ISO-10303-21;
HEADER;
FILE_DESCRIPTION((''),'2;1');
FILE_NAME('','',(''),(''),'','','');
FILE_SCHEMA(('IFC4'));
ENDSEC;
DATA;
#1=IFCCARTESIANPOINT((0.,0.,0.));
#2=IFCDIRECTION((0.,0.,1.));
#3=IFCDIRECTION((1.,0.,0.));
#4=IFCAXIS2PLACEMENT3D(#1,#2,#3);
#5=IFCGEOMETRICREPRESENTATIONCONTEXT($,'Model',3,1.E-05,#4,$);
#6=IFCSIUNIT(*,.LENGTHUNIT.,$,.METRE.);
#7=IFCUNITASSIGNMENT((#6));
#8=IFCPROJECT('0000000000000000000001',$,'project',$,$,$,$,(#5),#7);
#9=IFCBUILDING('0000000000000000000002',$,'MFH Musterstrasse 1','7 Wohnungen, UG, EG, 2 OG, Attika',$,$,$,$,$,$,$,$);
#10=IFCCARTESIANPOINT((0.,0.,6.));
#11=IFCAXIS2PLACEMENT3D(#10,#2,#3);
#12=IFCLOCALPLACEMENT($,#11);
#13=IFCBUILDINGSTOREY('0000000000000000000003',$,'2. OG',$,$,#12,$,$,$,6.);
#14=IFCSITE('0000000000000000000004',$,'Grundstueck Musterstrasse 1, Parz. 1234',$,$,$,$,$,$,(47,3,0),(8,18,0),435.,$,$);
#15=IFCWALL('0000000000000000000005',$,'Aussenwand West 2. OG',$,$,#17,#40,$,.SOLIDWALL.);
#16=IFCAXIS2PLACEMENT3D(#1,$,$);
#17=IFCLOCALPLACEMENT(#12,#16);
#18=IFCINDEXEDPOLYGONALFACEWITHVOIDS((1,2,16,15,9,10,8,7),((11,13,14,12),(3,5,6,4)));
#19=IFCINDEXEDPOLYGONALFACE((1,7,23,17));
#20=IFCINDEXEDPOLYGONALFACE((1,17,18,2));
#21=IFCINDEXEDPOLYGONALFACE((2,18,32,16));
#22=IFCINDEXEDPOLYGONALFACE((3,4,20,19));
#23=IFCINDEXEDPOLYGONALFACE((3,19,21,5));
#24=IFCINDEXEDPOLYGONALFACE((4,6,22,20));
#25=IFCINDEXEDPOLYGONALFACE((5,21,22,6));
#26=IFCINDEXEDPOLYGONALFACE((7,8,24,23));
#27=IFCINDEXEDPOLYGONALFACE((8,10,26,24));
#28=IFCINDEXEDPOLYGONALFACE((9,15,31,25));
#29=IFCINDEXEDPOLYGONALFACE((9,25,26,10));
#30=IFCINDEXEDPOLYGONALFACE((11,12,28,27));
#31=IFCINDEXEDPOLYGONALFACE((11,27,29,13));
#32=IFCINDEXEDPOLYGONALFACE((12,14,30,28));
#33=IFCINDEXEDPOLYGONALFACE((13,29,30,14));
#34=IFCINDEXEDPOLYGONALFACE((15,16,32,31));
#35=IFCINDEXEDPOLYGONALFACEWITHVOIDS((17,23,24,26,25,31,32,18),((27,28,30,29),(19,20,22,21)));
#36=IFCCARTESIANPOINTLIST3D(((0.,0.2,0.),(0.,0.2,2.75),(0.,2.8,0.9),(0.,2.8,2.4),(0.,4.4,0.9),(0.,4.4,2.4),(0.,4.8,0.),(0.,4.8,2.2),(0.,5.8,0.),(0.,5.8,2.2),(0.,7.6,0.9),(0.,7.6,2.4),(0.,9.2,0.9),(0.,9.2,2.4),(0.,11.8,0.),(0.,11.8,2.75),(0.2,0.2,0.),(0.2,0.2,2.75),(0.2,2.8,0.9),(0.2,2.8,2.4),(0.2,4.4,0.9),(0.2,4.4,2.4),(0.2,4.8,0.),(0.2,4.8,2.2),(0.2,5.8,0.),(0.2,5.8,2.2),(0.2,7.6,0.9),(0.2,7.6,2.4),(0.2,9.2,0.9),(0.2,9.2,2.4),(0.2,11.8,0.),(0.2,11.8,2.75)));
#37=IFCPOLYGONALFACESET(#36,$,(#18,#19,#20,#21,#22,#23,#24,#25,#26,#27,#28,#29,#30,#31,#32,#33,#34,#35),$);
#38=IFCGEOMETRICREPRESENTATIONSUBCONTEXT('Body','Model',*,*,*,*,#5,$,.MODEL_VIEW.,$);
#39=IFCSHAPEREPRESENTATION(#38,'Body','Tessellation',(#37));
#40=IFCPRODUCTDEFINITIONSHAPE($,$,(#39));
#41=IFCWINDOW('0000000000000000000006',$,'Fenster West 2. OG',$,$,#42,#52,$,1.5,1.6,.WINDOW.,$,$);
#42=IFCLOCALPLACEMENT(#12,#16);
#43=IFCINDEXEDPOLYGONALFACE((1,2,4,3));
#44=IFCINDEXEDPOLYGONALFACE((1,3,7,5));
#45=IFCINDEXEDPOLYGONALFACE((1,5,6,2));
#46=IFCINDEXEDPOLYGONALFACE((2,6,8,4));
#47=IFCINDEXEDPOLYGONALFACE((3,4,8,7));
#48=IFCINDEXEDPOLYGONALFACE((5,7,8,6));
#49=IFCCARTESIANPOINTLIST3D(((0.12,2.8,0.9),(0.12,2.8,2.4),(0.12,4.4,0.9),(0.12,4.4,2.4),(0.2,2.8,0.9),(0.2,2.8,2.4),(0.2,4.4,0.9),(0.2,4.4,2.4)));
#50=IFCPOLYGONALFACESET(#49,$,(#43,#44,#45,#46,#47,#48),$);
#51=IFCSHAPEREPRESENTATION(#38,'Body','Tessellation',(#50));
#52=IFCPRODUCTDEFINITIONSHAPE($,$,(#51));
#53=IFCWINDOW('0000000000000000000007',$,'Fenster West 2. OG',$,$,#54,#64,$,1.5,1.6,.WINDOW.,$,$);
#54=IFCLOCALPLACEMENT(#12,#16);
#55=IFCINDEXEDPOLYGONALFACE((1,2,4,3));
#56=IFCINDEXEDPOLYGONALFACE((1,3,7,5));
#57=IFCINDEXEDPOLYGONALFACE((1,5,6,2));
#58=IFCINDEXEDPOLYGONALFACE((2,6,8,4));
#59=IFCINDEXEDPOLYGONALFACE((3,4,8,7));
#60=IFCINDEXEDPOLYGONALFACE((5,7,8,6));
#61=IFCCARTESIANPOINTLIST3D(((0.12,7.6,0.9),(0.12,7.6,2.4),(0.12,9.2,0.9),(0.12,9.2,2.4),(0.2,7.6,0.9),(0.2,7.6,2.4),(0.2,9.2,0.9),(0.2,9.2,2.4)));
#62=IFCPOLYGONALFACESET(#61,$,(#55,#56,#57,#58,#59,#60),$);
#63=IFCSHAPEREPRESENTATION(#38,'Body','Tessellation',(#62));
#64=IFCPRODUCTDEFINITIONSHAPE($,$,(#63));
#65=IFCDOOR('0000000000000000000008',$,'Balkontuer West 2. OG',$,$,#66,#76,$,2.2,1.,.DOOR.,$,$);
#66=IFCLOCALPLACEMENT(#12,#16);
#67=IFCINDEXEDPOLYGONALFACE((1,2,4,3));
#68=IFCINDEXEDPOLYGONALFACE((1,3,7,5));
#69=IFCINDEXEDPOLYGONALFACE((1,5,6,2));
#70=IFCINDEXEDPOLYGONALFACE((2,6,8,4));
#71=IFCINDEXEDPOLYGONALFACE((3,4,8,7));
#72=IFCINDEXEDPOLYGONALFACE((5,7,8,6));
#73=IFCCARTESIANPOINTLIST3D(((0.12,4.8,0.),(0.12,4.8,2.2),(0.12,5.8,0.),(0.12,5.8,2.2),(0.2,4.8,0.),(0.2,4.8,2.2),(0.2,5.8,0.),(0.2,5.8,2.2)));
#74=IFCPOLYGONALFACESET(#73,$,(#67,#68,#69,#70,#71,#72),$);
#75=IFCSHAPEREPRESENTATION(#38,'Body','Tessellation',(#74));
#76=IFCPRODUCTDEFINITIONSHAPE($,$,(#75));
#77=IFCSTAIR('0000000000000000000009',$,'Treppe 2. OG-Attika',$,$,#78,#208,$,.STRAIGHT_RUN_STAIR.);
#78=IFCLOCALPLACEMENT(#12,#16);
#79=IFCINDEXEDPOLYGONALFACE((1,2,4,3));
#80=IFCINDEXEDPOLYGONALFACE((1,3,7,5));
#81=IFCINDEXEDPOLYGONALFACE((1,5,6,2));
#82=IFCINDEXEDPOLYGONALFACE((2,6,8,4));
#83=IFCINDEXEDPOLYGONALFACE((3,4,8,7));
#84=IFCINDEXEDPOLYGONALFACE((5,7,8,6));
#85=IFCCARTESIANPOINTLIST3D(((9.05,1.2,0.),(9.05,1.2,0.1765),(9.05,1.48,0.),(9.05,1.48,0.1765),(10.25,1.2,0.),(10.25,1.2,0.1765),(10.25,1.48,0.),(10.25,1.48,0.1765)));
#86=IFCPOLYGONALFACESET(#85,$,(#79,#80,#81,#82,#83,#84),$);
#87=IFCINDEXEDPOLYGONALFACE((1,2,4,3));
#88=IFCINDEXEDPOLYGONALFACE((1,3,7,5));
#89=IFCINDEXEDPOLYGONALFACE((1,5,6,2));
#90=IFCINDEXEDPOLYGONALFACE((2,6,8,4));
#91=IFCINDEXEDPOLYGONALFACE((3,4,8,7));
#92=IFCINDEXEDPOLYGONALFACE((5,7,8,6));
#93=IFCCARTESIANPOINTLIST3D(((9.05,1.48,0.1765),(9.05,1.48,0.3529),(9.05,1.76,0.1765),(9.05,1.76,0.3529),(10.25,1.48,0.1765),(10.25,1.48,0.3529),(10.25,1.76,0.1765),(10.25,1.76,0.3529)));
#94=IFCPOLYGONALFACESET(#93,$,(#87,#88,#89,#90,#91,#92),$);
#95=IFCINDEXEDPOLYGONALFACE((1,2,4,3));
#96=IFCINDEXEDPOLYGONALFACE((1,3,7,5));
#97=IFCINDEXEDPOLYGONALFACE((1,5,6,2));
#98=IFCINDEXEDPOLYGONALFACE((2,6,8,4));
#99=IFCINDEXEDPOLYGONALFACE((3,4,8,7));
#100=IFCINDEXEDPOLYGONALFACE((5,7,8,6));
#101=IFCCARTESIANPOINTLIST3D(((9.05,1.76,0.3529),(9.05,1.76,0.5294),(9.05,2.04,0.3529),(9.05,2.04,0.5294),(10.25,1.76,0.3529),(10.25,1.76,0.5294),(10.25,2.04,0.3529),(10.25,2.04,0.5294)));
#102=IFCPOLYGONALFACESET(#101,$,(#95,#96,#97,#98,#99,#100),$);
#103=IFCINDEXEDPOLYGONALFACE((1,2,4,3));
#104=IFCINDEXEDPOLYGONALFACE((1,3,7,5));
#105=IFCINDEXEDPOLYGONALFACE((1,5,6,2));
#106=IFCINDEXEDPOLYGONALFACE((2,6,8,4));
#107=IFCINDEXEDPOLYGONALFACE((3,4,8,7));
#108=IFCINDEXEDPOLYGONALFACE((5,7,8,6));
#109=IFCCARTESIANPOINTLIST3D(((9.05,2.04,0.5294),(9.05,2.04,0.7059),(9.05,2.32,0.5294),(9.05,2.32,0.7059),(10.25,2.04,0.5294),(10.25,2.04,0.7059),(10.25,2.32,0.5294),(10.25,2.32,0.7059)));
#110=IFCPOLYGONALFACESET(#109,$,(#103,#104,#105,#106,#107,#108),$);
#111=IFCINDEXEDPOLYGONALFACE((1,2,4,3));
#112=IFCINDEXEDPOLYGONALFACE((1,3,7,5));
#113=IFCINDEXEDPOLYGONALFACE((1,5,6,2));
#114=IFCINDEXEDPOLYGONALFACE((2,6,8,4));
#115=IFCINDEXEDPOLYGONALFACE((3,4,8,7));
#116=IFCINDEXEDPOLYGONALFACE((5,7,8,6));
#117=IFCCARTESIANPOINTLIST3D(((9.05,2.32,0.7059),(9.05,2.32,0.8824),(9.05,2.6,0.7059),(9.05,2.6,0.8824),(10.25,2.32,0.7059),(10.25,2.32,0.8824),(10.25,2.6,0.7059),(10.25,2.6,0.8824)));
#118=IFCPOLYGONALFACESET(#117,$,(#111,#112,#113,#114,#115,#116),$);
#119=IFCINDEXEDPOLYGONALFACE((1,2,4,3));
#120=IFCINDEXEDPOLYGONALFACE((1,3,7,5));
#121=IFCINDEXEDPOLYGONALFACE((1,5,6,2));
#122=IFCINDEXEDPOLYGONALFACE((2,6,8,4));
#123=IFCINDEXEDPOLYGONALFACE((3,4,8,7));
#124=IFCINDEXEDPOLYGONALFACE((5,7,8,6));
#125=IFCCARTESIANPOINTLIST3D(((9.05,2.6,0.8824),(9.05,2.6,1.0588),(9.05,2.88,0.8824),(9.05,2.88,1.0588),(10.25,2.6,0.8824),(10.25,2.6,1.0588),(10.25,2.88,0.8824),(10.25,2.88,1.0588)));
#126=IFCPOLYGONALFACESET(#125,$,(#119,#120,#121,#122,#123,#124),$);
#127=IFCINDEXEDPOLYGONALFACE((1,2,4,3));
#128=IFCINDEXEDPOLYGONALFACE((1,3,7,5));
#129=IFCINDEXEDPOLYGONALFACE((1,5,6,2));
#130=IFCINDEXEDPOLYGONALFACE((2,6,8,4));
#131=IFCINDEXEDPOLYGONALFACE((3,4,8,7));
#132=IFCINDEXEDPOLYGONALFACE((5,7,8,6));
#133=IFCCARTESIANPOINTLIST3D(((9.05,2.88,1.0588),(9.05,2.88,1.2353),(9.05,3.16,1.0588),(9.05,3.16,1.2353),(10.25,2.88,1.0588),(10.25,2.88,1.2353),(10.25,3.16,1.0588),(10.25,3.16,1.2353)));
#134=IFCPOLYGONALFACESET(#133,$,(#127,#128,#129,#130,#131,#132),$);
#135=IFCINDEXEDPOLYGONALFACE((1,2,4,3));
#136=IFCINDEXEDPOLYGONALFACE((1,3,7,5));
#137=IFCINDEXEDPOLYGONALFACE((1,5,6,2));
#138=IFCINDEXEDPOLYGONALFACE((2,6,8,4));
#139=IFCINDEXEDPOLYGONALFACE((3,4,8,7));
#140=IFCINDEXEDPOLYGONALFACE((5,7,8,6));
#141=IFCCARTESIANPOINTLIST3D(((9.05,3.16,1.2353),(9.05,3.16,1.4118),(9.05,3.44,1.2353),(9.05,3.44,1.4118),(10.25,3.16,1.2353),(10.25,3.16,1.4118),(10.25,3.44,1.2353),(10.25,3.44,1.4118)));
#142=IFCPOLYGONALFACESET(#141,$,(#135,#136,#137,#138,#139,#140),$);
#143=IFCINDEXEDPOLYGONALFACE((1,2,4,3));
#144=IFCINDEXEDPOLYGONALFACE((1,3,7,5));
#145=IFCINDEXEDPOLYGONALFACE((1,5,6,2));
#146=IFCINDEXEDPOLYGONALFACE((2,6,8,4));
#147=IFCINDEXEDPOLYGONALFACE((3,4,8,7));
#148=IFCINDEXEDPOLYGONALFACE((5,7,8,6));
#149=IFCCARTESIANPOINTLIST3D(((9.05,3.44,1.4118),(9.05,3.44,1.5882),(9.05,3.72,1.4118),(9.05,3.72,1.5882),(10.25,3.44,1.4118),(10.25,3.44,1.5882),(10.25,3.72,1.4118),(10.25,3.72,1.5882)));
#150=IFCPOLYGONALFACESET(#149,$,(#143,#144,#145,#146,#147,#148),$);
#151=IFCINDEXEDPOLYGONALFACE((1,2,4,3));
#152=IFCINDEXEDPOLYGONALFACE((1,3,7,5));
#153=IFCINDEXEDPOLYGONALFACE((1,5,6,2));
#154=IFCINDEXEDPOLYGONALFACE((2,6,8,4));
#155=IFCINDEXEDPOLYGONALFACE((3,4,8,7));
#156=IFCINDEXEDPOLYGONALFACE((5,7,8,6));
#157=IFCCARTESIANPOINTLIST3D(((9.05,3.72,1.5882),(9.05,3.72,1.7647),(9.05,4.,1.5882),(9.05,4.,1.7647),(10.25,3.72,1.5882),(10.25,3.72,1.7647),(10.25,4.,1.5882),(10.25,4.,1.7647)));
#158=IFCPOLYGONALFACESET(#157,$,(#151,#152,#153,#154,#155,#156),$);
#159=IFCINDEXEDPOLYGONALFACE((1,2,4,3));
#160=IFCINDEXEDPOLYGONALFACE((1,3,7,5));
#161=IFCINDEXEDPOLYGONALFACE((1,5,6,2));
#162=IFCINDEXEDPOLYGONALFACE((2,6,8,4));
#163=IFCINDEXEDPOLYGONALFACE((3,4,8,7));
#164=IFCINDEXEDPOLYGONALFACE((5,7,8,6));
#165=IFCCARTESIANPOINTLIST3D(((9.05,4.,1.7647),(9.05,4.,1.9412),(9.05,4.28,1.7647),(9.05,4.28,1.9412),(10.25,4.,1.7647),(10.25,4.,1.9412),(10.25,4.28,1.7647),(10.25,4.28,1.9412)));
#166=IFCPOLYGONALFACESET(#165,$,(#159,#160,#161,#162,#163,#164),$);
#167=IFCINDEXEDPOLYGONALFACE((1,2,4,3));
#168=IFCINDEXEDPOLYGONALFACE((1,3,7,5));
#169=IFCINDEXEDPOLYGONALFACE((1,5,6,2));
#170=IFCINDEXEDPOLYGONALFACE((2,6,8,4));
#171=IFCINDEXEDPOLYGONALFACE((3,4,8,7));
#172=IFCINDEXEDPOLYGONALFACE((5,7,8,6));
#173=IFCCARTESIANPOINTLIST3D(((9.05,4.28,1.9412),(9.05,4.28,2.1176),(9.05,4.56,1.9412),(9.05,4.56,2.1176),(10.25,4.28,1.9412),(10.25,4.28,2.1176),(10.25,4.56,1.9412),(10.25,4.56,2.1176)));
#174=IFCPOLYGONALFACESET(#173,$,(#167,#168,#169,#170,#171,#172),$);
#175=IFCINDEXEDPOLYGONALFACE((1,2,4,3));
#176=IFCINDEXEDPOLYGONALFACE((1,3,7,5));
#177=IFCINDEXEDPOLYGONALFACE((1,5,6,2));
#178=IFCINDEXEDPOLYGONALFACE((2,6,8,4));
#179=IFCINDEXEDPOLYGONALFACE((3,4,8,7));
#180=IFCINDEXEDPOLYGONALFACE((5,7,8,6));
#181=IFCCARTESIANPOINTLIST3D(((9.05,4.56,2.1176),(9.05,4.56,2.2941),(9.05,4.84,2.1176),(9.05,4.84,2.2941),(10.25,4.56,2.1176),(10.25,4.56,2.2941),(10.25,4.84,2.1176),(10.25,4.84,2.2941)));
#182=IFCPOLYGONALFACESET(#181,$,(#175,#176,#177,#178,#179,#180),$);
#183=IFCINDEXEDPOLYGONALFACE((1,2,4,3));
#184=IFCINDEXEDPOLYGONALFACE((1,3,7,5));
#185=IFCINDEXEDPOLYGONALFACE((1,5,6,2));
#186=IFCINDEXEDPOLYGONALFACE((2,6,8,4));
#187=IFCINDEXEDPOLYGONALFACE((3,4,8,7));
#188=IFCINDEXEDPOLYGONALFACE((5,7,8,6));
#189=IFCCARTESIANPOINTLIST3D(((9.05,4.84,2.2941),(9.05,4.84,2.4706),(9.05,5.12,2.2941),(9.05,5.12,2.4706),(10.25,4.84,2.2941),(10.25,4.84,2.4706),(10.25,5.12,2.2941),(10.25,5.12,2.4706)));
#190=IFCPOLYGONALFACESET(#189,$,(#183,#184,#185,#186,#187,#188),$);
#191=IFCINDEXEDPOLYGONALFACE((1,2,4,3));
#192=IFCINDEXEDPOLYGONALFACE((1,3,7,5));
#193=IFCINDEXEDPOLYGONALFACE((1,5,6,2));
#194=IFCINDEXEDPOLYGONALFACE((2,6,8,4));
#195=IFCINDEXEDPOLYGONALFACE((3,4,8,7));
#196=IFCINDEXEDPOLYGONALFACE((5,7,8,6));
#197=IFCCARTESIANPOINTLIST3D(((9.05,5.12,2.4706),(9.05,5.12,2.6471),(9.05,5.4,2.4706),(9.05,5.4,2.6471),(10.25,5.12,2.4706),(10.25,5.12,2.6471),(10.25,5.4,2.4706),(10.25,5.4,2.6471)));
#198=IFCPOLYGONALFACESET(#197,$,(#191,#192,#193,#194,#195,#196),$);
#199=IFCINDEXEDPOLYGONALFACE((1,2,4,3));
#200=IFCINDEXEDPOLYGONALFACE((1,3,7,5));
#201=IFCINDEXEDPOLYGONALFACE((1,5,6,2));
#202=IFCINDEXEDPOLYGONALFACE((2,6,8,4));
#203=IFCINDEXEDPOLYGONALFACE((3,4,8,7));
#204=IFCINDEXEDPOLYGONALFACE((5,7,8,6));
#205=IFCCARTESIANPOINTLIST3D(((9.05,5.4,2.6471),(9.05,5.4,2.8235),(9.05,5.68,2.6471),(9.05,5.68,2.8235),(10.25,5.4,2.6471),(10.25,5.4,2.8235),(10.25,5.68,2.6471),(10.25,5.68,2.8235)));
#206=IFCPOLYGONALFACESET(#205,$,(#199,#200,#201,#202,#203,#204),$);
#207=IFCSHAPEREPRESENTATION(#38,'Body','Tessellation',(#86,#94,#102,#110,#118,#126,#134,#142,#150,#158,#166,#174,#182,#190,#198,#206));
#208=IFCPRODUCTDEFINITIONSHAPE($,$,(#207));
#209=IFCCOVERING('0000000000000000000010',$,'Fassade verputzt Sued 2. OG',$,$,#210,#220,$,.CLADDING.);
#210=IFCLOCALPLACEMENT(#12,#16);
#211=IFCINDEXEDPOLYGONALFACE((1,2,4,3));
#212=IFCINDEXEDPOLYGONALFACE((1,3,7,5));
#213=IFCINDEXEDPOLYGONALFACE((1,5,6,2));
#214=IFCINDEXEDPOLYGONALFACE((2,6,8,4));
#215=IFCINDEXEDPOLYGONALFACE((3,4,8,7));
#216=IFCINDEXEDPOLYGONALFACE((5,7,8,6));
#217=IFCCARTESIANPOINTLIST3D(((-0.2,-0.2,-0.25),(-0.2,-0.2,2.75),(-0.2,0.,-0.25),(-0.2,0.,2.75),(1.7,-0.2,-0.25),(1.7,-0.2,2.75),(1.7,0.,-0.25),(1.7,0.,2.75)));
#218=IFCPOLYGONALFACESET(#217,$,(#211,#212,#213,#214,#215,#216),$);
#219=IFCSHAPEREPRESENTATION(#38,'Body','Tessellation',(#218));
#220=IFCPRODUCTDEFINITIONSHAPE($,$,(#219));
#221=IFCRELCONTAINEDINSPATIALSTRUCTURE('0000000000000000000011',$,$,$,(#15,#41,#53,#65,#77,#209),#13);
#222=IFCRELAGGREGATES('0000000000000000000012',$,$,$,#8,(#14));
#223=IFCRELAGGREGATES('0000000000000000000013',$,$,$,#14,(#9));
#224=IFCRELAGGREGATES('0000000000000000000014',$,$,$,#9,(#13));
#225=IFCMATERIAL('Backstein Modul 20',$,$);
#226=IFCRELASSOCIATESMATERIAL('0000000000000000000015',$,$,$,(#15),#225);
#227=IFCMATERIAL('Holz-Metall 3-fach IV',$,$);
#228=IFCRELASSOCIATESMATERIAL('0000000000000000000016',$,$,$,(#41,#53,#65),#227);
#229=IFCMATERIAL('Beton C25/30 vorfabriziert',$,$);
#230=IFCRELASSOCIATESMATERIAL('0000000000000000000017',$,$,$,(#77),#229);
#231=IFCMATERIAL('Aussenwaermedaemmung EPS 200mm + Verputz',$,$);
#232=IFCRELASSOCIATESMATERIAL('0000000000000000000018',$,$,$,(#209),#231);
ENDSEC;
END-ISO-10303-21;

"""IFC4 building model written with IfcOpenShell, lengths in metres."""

from ifc_helpers import new_model, si_unit, frame, frame_2d, origin_with_axes, place, context, subcontext, project, spatial, rectangle, extrude, material, element, fill, save


model = new_model("IFC4")

# Units and contexts
model_context = context("Model", 3, precision=1e-05, world=origin_with_axes())
body_context = subcontext(model_context, "Body", "Model", "MODEL_VIEW")
ifc_project = project(units=[si_unit("LENGTHUNIT", "METRE")], contexts=[model_context])

# Site, building, storey
site = spatial("IfcSite", under=ifc_project, Name="Grundstueck Musterstrasse 1, Parz. 1234", RefLatitude=(47, 3, 0), RefLongitude=(8, 18, 0), RefElevation=435.0)
building = spatial("IfcBuilding", under=site, Name="MFH Musterstrasse 1", Description="7 Wohnungen, UG, EG, 2 OG, Attika")
storey_placement = place(None, frame((0.0, 0.0, 6.0), z_axis=(0.0, 0.0, 1.0), x_axis=(1.0, 0.0, 0.0)))
storey = spatial("IfcBuildingStorey", under=building, at=storey_placement, Name="2. OG", Elevation=6.0)

# Shared definitions
ifc_material_1 = material(Name="Backstein Modul 20")

# Shared definitions
ifc_material_2 = material(Name="Holz-Metall 3-fach IV")

# Wall, openings, windows, door
wall_1_placement = place(storey_placement, frame((0.0, 0.2, 0.0), z_axis=(0.0, 0.0, 1.0), x_axis=(1.0, 0.0, 0.0)))
wall_1 = element("IfcWall", 1, at=wall_1_placement, inside=storey, material=ifc_material_1, Name="Aussenwand West 2. OG", PredefinedType="SOLIDWALL", context=body_context, shape_type="SweptSolid", body=[
    extrude(rectangle(XDim=0.2, YDim=11.6, at=frame_2d((0.1, 5.8))), origin_with_axes(), (0.0, 0.0, 1.0), 2.75),
])
opening_1_placement = place(wall_1_placement, frame((-0.21, 2.6, 0.9), z_axis=(0.0, 0.0, 1.0), x_axis=(1.0, 0.0, 0.0)))
opening_1 = element("IfcOpeningElement", 2, at=opening_1_placement, cuts=wall_1, context=body_context, shape_type="SweptSolid", body=[
    extrude(rectangle(XDim=0.42, YDim=1.6, at=frame_2d((0.21, 0.8))), origin_with_axes(), (0.0, 0.0, 1.0), 1.5),
])
opening_2_placement = place(wall_1_placement, frame((-0.21, 7.4, 0.9), z_axis=(0.0, 0.0, 1.0), x_axis=(1.0, 0.0, 0.0)))
opening_2 = element("IfcOpeningElement", 3, at=opening_2_placement, cuts=wall_1, context=body_context, shape_type="SweptSolid", body=[
    extrude(rectangle(XDim=0.42, YDim=1.6, at=frame_2d((0.21, 0.8))), origin_with_axes(), (0.0, 0.0, 1.0), 1.5),
])
opening_3_placement = place(wall_1_placement, frame((-0.21, 4.6, 0.0), z_axis=(0.0, 0.0, 1.0), x_axis=(1.0, 0.0, 0.0)))
opening_3 = element("IfcOpeningElement", 4, at=opening_3_placement, cuts=wall_1, context=body_context, shape_type="SweptSolid", body=[
    extrude(rectangle(XDim=0.42, YDim=1.0, at=frame_2d((0.21, 0.5))), origin_with_axes(), (0.0, 0.0, 1.0), 2.2),
])
window_1_placement = place(storey_placement, frame((0.12, 2.8, 0.9), z_axis=(0.0, 0.0, 1.0), x_axis=(1.0, 0.0, 0.0)))
window_1 = element("IfcWindow", 5, at=window_1_placement, inside=storey, material=ifc_material_2, Name="Fenster West 2. OG", OverallHeight=1.5, OverallWidth=1.6, PredefinedType="WINDOW", context=body_context, shape_type="SweptSolid", body=[
    extrude(rectangle(XDim=0.08, YDim=1.6, at=frame_2d((0.04, 0.8))), origin_with_axes(), (0.0, 0.0, 1.0), 1.5),
])
fill(opening_1, window_1)
window_2_placement = place(storey_placement, frame((0.12, 7.6, 0.9), z_axis=(0.0, 0.0, 1.0), x_axis=(1.0, 0.0, 0.0)))
window_2 = element("IfcWindow", 6, at=window_2_placement, inside=storey, material=ifc_material_2, Name="Fenster West 2. OG", OverallHeight=1.5, OverallWidth=1.6, PredefinedType="WINDOW", context=body_context, shape_type="SweptSolid", body=[
    extrude(rectangle(XDim=0.08, YDim=1.6, at=frame_2d((0.04, 0.8))), origin_with_axes(), (0.0, 0.0, 1.0), 1.5),
])
fill(opening_2, window_2)
door_1_placement = place(storey_placement, frame((0.12, 4.8, 0.0), z_axis=(0.0, 0.0, 1.0), x_axis=(1.0, 0.0, 0.0)))
door_1 = element("IfcDoor", 7, at=door_1_placement, inside=storey, material=ifc_material_2, Name="Balkontuer West 2. OG", OverallHeight=2.2, OverallWidth=1.0, PredefinedType="DOOR", context=body_context, shape_type="SweptSolid", body=[
    extrude(rectangle(XDim=0.08, YDim=1.0, at=frame_2d((0.04, 0.5))), origin_with_axes(), (0.0, 0.0, 1.0), 2.2),
])
fill(opening_3, door_1)

# Stair
ifc_material_3 = material(Name="Beton C25/30 vorfabriziert")
stair_placement = place(storey_placement, origin_with_axes())
element("IfcStair", 8, at=stair_placement, inside=storey, material=ifc_material_3, Name="Treppe 2. OG-Attika", PredefinedType="STRAIGHT_RUN_STAIR", context=body_context, shape_type="SweptSolid", body=[
    extrude(rectangle(XDim=1.2, YDim=0.28, at=frame_2d((0.6, 0.14))), frame((9.05, 1.2, 0.0)), (0.0, 0.0, 1.0), 0.1765),
    extrude(rectangle(XDim=1.2, YDim=0.28, at=frame_2d((0.6, 0.14))), frame((9.05, 1.48, 0.1765)), (0.0, 0.0, 1.0), 0.1765),
    extrude(rectangle(XDim=1.2, YDim=0.28, at=frame_2d((0.6, 0.14))), frame((9.05, 1.76, 0.3529)), (0.0, 0.0, 1.0), 0.1765),
    extrude(rectangle(XDim=1.2, YDim=0.28, at=frame_2d((0.6, 0.14))), frame((9.05, 2.04, 0.5294)), (0.0, 0.0, 1.0), 0.1765),
    extrude(rectangle(XDim=1.2, YDim=0.28, at=frame_2d((0.6, 0.14))), frame((9.05, 2.32, 0.7059)), (0.0, 0.0, 1.0), 0.1765),
    extrude(rectangle(XDim=1.2, YDim=0.28, at=frame_2d((0.6, 0.14))), frame((9.05, 2.6, 0.8824)), (0.0, 0.0, 1.0), 0.1765),
    extrude(rectangle(XDim=1.2, YDim=0.28, at=frame_2d((0.6, 0.14))), frame((9.05, 2.88, 1.0588)), (0.0, 0.0, 1.0), 0.1765),
    extrude(rectangle(XDim=1.2, YDim=0.28, at=frame_2d((0.6, 0.14))), frame((9.05, 3.16, 1.2353)), (0.0, 0.0, 1.0), 0.1765),
    extrude(rectangle(XDim=1.2, YDim=0.28, at=frame_2d((0.6, 0.14))), frame((9.05, 3.44, 1.4118)), (0.0, 0.0, 1.0), 0.1765),
    extrude(rectangle(XDim=1.2, YDim=0.28, at=frame_2d((0.6, 0.14))), frame((9.05, 3.72, 1.5882)), (0.0, 0.0, 1.0), 0.1765),
    extrude(rectangle(XDim=1.2, YDim=0.28, at=frame_2d((0.6, 0.14))), frame((9.05, 4.0, 1.7647)), (0.0, 0.0, 1.0), 0.1765),
    extrude(rectangle(XDim=1.2, YDim=0.28, at=frame_2d((0.6, 0.14))), frame((9.05, 4.28, 1.9412)), (0.0, 0.0, 1.0), 0.1765),
    extrude(rectangle(XDim=1.2, YDim=0.28, at=frame_2d((0.6, 0.14))), frame((9.05, 4.56, 2.1176)), (0.0, 0.0, 1.0), 0.1765),
    extrude(rectangle(XDim=1.2, YDim=0.28, at=frame_2d((0.6, 0.14))), frame((9.05, 4.84, 2.2941)), (0.0, 0.0, 1.0), 0.1765),
    extrude(rectangle(XDim=1.2, YDim=0.28, at=frame_2d((0.6, 0.14))), frame((9.05, 5.12, 2.4706)), (0.0, 0.0, 1.0), 0.1765),
    extrude(rectangle(XDim=1.2, YDim=0.28, at=frame_2d((0.6, 0.14))), frame((9.05, 5.4, 2.6471)), (0.0, 0.0, 1.0), 0.1765),
])

# Shared definitions
ifc_material_4 = material(Name="Aussenwaermedaemmung EPS 200mm + Verputz")

# Covering
covering_1_placement = place(storey_placement, frame((-0.2, -0.2, -0.25), z_axis=(0.0, 0.0, 1.0), x_axis=(1.0, 0.0, 0.0)))
element("IfcCovering", 9, at=covering_1_placement, inside=storey, material=ifc_material_4, Name="Fassade verputzt Sued 2. OG", PredefinedType="CLADDING", context=body_context, shape_type="SweptSolid", body=[
    extrude(rectangle(XDim=1.9, YDim=0.2, at=frame_2d((0.95, 0.1))), origin_with_axes(), (0.0, 0.0, 1.0), 3.0),
])

save(model, "model.ifc")
